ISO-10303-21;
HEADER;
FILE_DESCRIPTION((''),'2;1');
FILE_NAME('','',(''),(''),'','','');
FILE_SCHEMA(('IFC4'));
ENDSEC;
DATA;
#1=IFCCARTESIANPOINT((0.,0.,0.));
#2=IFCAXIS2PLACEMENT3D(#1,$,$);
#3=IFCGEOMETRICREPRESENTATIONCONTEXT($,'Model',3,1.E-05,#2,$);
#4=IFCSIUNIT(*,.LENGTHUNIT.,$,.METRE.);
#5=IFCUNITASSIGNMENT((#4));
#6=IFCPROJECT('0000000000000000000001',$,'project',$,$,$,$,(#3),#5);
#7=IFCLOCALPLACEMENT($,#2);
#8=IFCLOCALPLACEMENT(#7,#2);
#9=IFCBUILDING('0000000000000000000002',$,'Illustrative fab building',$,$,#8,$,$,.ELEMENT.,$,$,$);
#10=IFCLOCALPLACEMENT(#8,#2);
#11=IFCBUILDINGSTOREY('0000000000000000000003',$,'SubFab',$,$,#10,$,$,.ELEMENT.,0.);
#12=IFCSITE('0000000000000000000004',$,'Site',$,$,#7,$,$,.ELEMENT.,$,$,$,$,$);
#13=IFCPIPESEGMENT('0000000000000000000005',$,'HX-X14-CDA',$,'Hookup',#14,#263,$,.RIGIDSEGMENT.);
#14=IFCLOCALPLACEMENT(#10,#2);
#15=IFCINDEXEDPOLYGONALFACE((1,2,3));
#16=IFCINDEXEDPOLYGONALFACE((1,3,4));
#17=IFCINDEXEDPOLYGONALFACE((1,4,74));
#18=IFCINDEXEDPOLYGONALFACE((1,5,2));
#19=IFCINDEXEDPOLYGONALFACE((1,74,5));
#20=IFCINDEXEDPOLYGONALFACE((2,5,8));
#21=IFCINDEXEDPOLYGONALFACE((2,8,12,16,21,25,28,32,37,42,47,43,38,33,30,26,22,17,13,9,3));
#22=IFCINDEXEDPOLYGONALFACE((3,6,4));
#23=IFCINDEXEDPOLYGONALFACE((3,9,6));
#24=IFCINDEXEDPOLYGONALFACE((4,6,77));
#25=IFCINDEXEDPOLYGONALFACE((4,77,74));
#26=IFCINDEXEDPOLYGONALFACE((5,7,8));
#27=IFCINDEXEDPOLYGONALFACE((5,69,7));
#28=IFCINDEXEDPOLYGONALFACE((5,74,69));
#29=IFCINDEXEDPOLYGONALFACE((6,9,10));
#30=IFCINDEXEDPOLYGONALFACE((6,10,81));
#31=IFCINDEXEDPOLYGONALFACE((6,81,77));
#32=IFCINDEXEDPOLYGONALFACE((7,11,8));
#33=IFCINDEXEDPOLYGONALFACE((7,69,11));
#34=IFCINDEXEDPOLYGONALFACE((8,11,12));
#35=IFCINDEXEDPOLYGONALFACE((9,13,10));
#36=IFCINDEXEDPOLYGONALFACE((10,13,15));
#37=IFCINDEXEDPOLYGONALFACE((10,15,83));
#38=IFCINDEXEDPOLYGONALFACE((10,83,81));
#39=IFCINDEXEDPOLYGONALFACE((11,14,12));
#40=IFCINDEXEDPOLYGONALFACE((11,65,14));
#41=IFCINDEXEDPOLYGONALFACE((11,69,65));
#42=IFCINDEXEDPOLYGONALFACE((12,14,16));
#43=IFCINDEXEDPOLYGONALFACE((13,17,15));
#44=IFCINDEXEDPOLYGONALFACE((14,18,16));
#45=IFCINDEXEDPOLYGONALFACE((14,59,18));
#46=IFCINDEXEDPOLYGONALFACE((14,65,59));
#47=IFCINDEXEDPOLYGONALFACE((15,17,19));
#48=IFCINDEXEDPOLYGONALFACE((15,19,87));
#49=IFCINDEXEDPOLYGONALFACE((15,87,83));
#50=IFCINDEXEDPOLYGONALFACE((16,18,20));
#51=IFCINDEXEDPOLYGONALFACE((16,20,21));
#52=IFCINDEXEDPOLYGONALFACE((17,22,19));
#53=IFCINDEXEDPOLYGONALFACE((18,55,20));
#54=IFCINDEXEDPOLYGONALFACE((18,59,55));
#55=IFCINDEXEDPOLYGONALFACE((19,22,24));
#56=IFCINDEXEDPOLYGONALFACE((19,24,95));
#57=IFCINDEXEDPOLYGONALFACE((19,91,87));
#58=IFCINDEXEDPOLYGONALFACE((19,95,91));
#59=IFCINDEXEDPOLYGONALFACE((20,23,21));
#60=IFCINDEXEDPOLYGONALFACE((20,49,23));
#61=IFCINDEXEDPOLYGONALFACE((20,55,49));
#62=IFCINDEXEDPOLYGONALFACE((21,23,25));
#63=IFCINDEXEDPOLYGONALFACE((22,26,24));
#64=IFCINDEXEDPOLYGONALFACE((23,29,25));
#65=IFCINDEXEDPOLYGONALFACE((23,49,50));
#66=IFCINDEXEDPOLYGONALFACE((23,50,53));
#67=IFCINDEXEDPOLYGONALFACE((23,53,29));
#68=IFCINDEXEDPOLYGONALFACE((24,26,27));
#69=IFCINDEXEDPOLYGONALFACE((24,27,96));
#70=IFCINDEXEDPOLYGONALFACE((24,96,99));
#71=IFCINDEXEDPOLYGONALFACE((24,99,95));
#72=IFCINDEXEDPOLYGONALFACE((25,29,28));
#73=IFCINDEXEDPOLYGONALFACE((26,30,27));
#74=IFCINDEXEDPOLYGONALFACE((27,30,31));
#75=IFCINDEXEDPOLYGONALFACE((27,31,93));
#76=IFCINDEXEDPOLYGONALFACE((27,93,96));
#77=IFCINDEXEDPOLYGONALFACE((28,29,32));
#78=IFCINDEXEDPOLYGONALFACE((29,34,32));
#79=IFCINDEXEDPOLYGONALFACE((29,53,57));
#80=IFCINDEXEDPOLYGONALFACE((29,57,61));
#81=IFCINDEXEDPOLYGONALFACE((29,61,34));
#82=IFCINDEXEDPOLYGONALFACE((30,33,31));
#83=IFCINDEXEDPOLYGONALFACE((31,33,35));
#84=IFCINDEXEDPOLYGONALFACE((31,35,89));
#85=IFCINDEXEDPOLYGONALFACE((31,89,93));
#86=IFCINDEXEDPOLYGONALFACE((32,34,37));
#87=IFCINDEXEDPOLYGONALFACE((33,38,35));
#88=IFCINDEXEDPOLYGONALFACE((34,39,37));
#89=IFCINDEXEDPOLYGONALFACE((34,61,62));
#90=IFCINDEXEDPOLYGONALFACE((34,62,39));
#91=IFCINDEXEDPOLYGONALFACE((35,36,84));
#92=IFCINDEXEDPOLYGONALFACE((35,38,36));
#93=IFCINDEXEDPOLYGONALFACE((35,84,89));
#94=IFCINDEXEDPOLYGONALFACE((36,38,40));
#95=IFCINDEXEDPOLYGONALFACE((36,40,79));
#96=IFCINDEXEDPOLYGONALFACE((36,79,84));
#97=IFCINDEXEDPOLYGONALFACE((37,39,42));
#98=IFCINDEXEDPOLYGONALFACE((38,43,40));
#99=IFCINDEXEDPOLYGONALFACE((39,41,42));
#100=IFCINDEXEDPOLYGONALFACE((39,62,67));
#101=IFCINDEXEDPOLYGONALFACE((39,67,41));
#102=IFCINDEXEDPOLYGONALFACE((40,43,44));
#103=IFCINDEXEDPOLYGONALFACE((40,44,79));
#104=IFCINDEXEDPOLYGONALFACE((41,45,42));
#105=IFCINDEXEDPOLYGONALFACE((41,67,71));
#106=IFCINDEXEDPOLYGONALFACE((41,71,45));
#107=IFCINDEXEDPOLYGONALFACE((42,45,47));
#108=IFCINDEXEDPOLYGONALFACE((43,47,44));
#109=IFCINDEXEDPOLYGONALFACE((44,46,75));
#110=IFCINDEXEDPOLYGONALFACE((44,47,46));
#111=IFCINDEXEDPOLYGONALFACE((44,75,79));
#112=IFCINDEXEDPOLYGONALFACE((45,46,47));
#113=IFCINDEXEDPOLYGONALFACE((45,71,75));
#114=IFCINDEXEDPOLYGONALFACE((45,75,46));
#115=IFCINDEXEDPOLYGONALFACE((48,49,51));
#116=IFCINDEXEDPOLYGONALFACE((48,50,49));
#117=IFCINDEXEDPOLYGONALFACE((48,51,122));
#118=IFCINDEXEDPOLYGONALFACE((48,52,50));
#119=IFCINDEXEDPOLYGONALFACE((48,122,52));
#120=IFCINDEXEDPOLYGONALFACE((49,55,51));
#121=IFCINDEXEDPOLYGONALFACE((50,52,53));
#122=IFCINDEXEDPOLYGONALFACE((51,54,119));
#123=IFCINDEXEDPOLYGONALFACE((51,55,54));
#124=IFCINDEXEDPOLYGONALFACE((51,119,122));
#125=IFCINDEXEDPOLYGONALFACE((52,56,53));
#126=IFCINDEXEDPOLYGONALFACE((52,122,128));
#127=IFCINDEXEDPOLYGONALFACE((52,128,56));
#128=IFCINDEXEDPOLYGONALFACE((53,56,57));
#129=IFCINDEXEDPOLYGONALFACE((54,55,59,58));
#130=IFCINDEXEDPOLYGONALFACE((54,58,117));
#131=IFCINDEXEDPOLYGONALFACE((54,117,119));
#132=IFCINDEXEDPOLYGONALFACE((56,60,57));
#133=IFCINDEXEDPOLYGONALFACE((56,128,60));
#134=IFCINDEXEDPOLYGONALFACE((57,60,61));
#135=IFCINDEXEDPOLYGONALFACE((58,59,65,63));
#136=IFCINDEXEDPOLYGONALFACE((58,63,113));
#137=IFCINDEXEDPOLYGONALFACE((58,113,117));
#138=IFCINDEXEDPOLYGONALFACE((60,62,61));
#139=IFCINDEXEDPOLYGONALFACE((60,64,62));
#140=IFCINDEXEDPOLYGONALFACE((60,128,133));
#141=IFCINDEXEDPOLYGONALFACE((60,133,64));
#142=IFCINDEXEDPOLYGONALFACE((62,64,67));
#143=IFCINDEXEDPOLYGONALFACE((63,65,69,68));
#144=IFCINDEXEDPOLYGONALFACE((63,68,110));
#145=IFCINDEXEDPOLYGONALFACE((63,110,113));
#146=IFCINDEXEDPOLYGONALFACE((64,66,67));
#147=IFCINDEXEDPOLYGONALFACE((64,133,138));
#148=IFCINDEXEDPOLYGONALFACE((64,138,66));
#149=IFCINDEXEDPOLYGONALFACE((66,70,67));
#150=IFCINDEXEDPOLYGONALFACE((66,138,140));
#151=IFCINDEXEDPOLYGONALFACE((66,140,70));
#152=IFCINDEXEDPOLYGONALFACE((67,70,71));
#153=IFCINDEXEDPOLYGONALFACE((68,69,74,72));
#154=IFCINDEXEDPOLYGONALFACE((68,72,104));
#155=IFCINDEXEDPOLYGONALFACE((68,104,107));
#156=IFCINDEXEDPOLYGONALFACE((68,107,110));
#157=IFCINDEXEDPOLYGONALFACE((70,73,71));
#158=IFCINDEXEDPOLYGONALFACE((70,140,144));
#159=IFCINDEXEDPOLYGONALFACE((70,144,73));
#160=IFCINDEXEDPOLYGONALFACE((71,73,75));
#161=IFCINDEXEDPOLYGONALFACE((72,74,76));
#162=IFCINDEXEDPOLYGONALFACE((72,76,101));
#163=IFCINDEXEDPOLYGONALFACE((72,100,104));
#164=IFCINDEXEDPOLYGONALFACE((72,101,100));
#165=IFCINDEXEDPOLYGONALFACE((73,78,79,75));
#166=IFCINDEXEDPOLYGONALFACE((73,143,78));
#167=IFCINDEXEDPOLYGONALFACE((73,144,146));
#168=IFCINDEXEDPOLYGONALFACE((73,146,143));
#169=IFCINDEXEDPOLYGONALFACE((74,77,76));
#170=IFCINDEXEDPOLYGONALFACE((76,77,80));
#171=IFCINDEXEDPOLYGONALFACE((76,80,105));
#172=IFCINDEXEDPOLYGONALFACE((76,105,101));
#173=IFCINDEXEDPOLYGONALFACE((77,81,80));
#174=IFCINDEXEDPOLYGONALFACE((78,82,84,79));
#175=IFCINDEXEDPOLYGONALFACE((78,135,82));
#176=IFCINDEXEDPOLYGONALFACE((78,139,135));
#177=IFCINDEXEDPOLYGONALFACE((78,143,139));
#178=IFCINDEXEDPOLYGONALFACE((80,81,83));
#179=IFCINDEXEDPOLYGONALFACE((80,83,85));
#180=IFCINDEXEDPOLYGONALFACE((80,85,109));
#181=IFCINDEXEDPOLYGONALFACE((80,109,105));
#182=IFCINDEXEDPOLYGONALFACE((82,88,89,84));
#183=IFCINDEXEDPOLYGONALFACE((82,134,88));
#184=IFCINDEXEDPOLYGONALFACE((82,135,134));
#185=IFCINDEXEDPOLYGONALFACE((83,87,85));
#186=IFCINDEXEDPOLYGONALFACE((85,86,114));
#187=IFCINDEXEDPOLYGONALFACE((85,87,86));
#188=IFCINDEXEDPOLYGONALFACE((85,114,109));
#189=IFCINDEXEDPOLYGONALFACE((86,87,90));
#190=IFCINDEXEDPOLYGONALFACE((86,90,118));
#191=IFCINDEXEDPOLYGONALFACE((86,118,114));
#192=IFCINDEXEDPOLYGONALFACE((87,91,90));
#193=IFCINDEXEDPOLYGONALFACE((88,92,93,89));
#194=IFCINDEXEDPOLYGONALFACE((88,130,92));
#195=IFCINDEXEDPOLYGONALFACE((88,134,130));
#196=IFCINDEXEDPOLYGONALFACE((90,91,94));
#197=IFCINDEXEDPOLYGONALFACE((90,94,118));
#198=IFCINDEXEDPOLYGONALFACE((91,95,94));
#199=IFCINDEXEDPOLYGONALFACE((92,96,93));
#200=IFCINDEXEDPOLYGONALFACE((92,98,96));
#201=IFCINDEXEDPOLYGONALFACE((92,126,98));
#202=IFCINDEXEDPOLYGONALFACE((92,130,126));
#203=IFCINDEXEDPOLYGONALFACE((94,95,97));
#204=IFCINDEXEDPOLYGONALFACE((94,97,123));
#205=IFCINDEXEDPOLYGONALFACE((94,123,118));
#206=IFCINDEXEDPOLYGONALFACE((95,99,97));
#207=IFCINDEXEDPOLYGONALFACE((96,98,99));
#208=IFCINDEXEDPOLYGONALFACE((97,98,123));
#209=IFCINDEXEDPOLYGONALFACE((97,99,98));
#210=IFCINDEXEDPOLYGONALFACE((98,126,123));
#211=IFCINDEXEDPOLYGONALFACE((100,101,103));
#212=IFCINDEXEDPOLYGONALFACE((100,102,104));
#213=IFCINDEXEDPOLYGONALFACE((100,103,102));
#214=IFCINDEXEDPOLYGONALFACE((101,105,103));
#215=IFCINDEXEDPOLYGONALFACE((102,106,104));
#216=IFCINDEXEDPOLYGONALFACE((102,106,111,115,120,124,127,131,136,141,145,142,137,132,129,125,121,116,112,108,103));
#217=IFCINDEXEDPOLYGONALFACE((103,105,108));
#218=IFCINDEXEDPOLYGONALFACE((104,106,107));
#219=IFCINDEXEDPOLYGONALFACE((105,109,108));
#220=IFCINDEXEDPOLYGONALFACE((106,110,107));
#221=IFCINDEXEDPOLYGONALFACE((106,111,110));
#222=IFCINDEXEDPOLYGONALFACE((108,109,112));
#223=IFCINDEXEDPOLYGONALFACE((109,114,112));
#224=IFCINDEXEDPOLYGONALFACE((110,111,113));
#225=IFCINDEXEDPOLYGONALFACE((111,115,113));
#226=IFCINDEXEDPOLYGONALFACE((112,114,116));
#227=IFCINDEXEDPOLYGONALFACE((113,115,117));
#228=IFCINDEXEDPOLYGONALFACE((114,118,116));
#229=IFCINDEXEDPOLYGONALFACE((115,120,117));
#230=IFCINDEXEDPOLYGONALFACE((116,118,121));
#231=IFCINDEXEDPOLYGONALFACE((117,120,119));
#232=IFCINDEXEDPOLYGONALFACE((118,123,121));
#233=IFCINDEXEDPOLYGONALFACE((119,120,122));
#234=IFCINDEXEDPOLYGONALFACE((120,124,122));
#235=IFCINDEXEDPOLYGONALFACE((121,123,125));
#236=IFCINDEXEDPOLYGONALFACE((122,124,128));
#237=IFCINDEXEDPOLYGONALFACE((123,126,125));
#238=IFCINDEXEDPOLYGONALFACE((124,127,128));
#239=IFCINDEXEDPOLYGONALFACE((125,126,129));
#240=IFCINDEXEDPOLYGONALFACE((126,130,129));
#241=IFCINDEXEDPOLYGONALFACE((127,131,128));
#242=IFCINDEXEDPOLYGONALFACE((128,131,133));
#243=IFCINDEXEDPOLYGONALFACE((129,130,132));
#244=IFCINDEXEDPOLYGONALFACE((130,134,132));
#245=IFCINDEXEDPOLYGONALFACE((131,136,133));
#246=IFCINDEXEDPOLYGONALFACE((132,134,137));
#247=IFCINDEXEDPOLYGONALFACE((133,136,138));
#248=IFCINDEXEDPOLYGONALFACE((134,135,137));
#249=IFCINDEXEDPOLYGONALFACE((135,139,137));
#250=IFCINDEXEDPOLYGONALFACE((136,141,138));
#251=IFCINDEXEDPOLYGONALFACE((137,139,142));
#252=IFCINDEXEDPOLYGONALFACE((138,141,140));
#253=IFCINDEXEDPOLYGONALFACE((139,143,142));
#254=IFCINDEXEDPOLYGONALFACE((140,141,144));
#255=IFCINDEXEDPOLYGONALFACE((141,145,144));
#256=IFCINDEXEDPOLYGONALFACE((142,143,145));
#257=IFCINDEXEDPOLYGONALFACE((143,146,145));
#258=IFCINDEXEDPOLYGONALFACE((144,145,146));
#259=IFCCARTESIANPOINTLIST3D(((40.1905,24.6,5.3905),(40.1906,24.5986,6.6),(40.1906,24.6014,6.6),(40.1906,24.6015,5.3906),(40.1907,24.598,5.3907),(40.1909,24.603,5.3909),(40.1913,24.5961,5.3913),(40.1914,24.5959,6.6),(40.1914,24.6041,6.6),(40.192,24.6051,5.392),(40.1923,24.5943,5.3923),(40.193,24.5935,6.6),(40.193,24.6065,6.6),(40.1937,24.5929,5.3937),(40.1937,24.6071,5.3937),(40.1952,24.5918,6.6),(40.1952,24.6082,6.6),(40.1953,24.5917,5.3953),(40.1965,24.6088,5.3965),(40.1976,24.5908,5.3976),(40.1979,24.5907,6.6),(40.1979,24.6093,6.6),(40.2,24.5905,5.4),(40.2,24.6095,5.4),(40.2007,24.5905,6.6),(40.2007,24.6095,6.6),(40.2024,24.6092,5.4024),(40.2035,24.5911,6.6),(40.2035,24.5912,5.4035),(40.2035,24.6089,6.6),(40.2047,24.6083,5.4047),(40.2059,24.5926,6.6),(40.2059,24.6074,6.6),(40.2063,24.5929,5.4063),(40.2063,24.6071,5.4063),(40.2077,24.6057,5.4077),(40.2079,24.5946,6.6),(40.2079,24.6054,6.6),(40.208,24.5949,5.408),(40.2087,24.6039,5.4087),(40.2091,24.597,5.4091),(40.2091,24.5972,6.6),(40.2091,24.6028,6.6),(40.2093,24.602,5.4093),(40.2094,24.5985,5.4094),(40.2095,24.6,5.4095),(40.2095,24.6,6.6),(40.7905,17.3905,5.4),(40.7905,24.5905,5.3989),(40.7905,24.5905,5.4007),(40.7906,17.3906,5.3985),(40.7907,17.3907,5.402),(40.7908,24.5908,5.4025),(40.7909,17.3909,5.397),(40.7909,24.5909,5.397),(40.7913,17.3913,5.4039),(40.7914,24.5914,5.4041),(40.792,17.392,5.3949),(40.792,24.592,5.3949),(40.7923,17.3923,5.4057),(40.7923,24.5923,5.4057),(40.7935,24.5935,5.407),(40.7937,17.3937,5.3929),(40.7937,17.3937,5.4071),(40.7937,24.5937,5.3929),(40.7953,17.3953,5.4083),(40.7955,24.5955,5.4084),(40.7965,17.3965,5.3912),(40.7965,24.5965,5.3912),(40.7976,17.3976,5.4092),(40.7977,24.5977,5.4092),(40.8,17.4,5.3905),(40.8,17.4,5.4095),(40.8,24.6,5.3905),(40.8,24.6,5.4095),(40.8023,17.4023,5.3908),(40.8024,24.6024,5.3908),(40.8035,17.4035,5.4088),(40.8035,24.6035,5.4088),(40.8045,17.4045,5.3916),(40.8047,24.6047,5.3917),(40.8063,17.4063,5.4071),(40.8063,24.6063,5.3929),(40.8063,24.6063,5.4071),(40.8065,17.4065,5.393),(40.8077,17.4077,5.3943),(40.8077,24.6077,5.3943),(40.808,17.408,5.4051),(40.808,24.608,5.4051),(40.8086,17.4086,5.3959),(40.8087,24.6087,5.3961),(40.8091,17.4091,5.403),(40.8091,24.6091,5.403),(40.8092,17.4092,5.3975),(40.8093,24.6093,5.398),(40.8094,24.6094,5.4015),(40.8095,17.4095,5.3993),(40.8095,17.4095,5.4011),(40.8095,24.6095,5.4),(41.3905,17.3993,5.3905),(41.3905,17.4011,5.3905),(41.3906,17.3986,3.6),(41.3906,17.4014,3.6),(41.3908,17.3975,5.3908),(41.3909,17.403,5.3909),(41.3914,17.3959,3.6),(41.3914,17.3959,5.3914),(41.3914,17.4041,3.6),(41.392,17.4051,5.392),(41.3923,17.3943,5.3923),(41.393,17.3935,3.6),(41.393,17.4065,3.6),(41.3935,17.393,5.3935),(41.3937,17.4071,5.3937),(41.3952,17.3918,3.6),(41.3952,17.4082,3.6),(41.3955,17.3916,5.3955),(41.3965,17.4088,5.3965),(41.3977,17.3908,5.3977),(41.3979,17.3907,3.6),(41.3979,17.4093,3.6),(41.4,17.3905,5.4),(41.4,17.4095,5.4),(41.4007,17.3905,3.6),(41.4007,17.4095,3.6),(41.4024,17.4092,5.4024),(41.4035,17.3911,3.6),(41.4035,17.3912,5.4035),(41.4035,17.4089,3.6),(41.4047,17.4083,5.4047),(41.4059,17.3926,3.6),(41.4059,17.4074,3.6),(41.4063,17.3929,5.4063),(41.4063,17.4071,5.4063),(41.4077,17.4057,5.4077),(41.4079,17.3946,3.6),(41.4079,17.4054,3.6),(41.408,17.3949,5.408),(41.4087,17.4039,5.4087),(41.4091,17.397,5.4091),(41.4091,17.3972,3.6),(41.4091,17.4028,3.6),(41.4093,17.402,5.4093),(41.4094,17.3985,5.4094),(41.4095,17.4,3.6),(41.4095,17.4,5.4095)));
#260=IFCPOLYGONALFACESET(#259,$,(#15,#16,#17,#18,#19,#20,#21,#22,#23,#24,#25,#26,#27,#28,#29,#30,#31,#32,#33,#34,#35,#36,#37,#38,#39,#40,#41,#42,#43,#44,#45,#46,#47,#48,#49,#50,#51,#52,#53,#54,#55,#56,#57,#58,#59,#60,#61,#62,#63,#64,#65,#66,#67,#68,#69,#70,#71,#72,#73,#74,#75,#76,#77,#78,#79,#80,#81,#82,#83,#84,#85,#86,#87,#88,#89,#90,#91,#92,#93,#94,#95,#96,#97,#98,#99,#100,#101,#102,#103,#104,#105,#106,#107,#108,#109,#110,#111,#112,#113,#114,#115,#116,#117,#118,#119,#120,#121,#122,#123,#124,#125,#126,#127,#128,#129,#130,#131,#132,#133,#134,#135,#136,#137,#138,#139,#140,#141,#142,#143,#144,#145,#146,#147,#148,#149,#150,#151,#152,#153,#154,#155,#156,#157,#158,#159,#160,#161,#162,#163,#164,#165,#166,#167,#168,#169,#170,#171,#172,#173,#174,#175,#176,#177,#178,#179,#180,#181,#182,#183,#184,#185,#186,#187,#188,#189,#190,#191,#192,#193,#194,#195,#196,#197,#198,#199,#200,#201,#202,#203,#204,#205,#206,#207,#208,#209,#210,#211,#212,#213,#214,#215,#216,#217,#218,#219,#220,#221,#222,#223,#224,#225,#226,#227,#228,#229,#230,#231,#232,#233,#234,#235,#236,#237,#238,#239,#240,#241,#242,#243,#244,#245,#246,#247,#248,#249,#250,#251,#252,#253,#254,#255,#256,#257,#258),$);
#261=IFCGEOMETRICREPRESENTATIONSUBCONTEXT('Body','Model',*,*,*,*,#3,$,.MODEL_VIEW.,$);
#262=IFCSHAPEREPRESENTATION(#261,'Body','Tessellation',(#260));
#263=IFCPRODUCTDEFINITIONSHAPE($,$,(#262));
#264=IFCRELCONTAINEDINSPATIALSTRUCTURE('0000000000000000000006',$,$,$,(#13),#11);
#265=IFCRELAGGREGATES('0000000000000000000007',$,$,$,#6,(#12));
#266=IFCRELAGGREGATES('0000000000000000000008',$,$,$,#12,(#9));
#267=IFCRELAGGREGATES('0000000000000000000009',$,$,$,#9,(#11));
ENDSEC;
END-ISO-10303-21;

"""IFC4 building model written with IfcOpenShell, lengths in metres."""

from ifc_helpers import new_model, entity, si_unit, origin, place, context, subcontext, project, spatial, element, save


model = new_model("IFC4")

# Units and contexts
model_context = context("Model", 3, precision=1e-05, world=origin())
body_context = subcontext(model_context, "Body", "Model", "MODEL_VIEW")
ifc_project = project(units=[si_unit("LENGTHUNIT", "METRE")], contexts=[model_context])

# Site, building, storey
site_placement = place(None, origin())
site = spatial("IfcSite", under=ifc_project, at=site_placement, Name="Site", CompositionType="ELEMENT")
building_placement = place(site_placement, origin())
building = spatial("IfcBuilding", under=site, at=building_placement, Name="Illustrative fab building", CompositionType="ELEMENT")
storey_placement = place(building_placement, origin())
storey = spatial("IfcBuildingStorey", under=building, at=storey_placement, Name="SubFab", CompositionType="ELEMENT", Elevation=0.0)

# Pipe segment
pipe_segment_1_placement = place(storey_placement, origin())
element("IfcPipeSegment", 1, at=pipe_segment_1_placement, inside=storey, Name="HX-X14-CDA", ObjectType="Hookup", PredefinedType="RIGIDSEGMENT", context=body_context, shape_type="AdvancedSweptSolid", body=[
    entity("IfcSweptDiskSolid", entity("IfcPolyline", [entity("IfcCartesianPoint", [41.4, 17.4, 3.6]), entity("IfcCartesianPoint", [41.4, 17.4, 5.4]), entity("IfcCartesianPoint", [40.8, 17.4, 5.4]), entity("IfcCartesianPoint", [40.8, 24.6, 5.4]), entity("IfcCartesianPoint", [40.2, 24.6, 5.4]), entity("IfcCartesianPoint", [40.2, 24.6, 6.6])]), 0.0095),
])

save(model, "model.ifc")
